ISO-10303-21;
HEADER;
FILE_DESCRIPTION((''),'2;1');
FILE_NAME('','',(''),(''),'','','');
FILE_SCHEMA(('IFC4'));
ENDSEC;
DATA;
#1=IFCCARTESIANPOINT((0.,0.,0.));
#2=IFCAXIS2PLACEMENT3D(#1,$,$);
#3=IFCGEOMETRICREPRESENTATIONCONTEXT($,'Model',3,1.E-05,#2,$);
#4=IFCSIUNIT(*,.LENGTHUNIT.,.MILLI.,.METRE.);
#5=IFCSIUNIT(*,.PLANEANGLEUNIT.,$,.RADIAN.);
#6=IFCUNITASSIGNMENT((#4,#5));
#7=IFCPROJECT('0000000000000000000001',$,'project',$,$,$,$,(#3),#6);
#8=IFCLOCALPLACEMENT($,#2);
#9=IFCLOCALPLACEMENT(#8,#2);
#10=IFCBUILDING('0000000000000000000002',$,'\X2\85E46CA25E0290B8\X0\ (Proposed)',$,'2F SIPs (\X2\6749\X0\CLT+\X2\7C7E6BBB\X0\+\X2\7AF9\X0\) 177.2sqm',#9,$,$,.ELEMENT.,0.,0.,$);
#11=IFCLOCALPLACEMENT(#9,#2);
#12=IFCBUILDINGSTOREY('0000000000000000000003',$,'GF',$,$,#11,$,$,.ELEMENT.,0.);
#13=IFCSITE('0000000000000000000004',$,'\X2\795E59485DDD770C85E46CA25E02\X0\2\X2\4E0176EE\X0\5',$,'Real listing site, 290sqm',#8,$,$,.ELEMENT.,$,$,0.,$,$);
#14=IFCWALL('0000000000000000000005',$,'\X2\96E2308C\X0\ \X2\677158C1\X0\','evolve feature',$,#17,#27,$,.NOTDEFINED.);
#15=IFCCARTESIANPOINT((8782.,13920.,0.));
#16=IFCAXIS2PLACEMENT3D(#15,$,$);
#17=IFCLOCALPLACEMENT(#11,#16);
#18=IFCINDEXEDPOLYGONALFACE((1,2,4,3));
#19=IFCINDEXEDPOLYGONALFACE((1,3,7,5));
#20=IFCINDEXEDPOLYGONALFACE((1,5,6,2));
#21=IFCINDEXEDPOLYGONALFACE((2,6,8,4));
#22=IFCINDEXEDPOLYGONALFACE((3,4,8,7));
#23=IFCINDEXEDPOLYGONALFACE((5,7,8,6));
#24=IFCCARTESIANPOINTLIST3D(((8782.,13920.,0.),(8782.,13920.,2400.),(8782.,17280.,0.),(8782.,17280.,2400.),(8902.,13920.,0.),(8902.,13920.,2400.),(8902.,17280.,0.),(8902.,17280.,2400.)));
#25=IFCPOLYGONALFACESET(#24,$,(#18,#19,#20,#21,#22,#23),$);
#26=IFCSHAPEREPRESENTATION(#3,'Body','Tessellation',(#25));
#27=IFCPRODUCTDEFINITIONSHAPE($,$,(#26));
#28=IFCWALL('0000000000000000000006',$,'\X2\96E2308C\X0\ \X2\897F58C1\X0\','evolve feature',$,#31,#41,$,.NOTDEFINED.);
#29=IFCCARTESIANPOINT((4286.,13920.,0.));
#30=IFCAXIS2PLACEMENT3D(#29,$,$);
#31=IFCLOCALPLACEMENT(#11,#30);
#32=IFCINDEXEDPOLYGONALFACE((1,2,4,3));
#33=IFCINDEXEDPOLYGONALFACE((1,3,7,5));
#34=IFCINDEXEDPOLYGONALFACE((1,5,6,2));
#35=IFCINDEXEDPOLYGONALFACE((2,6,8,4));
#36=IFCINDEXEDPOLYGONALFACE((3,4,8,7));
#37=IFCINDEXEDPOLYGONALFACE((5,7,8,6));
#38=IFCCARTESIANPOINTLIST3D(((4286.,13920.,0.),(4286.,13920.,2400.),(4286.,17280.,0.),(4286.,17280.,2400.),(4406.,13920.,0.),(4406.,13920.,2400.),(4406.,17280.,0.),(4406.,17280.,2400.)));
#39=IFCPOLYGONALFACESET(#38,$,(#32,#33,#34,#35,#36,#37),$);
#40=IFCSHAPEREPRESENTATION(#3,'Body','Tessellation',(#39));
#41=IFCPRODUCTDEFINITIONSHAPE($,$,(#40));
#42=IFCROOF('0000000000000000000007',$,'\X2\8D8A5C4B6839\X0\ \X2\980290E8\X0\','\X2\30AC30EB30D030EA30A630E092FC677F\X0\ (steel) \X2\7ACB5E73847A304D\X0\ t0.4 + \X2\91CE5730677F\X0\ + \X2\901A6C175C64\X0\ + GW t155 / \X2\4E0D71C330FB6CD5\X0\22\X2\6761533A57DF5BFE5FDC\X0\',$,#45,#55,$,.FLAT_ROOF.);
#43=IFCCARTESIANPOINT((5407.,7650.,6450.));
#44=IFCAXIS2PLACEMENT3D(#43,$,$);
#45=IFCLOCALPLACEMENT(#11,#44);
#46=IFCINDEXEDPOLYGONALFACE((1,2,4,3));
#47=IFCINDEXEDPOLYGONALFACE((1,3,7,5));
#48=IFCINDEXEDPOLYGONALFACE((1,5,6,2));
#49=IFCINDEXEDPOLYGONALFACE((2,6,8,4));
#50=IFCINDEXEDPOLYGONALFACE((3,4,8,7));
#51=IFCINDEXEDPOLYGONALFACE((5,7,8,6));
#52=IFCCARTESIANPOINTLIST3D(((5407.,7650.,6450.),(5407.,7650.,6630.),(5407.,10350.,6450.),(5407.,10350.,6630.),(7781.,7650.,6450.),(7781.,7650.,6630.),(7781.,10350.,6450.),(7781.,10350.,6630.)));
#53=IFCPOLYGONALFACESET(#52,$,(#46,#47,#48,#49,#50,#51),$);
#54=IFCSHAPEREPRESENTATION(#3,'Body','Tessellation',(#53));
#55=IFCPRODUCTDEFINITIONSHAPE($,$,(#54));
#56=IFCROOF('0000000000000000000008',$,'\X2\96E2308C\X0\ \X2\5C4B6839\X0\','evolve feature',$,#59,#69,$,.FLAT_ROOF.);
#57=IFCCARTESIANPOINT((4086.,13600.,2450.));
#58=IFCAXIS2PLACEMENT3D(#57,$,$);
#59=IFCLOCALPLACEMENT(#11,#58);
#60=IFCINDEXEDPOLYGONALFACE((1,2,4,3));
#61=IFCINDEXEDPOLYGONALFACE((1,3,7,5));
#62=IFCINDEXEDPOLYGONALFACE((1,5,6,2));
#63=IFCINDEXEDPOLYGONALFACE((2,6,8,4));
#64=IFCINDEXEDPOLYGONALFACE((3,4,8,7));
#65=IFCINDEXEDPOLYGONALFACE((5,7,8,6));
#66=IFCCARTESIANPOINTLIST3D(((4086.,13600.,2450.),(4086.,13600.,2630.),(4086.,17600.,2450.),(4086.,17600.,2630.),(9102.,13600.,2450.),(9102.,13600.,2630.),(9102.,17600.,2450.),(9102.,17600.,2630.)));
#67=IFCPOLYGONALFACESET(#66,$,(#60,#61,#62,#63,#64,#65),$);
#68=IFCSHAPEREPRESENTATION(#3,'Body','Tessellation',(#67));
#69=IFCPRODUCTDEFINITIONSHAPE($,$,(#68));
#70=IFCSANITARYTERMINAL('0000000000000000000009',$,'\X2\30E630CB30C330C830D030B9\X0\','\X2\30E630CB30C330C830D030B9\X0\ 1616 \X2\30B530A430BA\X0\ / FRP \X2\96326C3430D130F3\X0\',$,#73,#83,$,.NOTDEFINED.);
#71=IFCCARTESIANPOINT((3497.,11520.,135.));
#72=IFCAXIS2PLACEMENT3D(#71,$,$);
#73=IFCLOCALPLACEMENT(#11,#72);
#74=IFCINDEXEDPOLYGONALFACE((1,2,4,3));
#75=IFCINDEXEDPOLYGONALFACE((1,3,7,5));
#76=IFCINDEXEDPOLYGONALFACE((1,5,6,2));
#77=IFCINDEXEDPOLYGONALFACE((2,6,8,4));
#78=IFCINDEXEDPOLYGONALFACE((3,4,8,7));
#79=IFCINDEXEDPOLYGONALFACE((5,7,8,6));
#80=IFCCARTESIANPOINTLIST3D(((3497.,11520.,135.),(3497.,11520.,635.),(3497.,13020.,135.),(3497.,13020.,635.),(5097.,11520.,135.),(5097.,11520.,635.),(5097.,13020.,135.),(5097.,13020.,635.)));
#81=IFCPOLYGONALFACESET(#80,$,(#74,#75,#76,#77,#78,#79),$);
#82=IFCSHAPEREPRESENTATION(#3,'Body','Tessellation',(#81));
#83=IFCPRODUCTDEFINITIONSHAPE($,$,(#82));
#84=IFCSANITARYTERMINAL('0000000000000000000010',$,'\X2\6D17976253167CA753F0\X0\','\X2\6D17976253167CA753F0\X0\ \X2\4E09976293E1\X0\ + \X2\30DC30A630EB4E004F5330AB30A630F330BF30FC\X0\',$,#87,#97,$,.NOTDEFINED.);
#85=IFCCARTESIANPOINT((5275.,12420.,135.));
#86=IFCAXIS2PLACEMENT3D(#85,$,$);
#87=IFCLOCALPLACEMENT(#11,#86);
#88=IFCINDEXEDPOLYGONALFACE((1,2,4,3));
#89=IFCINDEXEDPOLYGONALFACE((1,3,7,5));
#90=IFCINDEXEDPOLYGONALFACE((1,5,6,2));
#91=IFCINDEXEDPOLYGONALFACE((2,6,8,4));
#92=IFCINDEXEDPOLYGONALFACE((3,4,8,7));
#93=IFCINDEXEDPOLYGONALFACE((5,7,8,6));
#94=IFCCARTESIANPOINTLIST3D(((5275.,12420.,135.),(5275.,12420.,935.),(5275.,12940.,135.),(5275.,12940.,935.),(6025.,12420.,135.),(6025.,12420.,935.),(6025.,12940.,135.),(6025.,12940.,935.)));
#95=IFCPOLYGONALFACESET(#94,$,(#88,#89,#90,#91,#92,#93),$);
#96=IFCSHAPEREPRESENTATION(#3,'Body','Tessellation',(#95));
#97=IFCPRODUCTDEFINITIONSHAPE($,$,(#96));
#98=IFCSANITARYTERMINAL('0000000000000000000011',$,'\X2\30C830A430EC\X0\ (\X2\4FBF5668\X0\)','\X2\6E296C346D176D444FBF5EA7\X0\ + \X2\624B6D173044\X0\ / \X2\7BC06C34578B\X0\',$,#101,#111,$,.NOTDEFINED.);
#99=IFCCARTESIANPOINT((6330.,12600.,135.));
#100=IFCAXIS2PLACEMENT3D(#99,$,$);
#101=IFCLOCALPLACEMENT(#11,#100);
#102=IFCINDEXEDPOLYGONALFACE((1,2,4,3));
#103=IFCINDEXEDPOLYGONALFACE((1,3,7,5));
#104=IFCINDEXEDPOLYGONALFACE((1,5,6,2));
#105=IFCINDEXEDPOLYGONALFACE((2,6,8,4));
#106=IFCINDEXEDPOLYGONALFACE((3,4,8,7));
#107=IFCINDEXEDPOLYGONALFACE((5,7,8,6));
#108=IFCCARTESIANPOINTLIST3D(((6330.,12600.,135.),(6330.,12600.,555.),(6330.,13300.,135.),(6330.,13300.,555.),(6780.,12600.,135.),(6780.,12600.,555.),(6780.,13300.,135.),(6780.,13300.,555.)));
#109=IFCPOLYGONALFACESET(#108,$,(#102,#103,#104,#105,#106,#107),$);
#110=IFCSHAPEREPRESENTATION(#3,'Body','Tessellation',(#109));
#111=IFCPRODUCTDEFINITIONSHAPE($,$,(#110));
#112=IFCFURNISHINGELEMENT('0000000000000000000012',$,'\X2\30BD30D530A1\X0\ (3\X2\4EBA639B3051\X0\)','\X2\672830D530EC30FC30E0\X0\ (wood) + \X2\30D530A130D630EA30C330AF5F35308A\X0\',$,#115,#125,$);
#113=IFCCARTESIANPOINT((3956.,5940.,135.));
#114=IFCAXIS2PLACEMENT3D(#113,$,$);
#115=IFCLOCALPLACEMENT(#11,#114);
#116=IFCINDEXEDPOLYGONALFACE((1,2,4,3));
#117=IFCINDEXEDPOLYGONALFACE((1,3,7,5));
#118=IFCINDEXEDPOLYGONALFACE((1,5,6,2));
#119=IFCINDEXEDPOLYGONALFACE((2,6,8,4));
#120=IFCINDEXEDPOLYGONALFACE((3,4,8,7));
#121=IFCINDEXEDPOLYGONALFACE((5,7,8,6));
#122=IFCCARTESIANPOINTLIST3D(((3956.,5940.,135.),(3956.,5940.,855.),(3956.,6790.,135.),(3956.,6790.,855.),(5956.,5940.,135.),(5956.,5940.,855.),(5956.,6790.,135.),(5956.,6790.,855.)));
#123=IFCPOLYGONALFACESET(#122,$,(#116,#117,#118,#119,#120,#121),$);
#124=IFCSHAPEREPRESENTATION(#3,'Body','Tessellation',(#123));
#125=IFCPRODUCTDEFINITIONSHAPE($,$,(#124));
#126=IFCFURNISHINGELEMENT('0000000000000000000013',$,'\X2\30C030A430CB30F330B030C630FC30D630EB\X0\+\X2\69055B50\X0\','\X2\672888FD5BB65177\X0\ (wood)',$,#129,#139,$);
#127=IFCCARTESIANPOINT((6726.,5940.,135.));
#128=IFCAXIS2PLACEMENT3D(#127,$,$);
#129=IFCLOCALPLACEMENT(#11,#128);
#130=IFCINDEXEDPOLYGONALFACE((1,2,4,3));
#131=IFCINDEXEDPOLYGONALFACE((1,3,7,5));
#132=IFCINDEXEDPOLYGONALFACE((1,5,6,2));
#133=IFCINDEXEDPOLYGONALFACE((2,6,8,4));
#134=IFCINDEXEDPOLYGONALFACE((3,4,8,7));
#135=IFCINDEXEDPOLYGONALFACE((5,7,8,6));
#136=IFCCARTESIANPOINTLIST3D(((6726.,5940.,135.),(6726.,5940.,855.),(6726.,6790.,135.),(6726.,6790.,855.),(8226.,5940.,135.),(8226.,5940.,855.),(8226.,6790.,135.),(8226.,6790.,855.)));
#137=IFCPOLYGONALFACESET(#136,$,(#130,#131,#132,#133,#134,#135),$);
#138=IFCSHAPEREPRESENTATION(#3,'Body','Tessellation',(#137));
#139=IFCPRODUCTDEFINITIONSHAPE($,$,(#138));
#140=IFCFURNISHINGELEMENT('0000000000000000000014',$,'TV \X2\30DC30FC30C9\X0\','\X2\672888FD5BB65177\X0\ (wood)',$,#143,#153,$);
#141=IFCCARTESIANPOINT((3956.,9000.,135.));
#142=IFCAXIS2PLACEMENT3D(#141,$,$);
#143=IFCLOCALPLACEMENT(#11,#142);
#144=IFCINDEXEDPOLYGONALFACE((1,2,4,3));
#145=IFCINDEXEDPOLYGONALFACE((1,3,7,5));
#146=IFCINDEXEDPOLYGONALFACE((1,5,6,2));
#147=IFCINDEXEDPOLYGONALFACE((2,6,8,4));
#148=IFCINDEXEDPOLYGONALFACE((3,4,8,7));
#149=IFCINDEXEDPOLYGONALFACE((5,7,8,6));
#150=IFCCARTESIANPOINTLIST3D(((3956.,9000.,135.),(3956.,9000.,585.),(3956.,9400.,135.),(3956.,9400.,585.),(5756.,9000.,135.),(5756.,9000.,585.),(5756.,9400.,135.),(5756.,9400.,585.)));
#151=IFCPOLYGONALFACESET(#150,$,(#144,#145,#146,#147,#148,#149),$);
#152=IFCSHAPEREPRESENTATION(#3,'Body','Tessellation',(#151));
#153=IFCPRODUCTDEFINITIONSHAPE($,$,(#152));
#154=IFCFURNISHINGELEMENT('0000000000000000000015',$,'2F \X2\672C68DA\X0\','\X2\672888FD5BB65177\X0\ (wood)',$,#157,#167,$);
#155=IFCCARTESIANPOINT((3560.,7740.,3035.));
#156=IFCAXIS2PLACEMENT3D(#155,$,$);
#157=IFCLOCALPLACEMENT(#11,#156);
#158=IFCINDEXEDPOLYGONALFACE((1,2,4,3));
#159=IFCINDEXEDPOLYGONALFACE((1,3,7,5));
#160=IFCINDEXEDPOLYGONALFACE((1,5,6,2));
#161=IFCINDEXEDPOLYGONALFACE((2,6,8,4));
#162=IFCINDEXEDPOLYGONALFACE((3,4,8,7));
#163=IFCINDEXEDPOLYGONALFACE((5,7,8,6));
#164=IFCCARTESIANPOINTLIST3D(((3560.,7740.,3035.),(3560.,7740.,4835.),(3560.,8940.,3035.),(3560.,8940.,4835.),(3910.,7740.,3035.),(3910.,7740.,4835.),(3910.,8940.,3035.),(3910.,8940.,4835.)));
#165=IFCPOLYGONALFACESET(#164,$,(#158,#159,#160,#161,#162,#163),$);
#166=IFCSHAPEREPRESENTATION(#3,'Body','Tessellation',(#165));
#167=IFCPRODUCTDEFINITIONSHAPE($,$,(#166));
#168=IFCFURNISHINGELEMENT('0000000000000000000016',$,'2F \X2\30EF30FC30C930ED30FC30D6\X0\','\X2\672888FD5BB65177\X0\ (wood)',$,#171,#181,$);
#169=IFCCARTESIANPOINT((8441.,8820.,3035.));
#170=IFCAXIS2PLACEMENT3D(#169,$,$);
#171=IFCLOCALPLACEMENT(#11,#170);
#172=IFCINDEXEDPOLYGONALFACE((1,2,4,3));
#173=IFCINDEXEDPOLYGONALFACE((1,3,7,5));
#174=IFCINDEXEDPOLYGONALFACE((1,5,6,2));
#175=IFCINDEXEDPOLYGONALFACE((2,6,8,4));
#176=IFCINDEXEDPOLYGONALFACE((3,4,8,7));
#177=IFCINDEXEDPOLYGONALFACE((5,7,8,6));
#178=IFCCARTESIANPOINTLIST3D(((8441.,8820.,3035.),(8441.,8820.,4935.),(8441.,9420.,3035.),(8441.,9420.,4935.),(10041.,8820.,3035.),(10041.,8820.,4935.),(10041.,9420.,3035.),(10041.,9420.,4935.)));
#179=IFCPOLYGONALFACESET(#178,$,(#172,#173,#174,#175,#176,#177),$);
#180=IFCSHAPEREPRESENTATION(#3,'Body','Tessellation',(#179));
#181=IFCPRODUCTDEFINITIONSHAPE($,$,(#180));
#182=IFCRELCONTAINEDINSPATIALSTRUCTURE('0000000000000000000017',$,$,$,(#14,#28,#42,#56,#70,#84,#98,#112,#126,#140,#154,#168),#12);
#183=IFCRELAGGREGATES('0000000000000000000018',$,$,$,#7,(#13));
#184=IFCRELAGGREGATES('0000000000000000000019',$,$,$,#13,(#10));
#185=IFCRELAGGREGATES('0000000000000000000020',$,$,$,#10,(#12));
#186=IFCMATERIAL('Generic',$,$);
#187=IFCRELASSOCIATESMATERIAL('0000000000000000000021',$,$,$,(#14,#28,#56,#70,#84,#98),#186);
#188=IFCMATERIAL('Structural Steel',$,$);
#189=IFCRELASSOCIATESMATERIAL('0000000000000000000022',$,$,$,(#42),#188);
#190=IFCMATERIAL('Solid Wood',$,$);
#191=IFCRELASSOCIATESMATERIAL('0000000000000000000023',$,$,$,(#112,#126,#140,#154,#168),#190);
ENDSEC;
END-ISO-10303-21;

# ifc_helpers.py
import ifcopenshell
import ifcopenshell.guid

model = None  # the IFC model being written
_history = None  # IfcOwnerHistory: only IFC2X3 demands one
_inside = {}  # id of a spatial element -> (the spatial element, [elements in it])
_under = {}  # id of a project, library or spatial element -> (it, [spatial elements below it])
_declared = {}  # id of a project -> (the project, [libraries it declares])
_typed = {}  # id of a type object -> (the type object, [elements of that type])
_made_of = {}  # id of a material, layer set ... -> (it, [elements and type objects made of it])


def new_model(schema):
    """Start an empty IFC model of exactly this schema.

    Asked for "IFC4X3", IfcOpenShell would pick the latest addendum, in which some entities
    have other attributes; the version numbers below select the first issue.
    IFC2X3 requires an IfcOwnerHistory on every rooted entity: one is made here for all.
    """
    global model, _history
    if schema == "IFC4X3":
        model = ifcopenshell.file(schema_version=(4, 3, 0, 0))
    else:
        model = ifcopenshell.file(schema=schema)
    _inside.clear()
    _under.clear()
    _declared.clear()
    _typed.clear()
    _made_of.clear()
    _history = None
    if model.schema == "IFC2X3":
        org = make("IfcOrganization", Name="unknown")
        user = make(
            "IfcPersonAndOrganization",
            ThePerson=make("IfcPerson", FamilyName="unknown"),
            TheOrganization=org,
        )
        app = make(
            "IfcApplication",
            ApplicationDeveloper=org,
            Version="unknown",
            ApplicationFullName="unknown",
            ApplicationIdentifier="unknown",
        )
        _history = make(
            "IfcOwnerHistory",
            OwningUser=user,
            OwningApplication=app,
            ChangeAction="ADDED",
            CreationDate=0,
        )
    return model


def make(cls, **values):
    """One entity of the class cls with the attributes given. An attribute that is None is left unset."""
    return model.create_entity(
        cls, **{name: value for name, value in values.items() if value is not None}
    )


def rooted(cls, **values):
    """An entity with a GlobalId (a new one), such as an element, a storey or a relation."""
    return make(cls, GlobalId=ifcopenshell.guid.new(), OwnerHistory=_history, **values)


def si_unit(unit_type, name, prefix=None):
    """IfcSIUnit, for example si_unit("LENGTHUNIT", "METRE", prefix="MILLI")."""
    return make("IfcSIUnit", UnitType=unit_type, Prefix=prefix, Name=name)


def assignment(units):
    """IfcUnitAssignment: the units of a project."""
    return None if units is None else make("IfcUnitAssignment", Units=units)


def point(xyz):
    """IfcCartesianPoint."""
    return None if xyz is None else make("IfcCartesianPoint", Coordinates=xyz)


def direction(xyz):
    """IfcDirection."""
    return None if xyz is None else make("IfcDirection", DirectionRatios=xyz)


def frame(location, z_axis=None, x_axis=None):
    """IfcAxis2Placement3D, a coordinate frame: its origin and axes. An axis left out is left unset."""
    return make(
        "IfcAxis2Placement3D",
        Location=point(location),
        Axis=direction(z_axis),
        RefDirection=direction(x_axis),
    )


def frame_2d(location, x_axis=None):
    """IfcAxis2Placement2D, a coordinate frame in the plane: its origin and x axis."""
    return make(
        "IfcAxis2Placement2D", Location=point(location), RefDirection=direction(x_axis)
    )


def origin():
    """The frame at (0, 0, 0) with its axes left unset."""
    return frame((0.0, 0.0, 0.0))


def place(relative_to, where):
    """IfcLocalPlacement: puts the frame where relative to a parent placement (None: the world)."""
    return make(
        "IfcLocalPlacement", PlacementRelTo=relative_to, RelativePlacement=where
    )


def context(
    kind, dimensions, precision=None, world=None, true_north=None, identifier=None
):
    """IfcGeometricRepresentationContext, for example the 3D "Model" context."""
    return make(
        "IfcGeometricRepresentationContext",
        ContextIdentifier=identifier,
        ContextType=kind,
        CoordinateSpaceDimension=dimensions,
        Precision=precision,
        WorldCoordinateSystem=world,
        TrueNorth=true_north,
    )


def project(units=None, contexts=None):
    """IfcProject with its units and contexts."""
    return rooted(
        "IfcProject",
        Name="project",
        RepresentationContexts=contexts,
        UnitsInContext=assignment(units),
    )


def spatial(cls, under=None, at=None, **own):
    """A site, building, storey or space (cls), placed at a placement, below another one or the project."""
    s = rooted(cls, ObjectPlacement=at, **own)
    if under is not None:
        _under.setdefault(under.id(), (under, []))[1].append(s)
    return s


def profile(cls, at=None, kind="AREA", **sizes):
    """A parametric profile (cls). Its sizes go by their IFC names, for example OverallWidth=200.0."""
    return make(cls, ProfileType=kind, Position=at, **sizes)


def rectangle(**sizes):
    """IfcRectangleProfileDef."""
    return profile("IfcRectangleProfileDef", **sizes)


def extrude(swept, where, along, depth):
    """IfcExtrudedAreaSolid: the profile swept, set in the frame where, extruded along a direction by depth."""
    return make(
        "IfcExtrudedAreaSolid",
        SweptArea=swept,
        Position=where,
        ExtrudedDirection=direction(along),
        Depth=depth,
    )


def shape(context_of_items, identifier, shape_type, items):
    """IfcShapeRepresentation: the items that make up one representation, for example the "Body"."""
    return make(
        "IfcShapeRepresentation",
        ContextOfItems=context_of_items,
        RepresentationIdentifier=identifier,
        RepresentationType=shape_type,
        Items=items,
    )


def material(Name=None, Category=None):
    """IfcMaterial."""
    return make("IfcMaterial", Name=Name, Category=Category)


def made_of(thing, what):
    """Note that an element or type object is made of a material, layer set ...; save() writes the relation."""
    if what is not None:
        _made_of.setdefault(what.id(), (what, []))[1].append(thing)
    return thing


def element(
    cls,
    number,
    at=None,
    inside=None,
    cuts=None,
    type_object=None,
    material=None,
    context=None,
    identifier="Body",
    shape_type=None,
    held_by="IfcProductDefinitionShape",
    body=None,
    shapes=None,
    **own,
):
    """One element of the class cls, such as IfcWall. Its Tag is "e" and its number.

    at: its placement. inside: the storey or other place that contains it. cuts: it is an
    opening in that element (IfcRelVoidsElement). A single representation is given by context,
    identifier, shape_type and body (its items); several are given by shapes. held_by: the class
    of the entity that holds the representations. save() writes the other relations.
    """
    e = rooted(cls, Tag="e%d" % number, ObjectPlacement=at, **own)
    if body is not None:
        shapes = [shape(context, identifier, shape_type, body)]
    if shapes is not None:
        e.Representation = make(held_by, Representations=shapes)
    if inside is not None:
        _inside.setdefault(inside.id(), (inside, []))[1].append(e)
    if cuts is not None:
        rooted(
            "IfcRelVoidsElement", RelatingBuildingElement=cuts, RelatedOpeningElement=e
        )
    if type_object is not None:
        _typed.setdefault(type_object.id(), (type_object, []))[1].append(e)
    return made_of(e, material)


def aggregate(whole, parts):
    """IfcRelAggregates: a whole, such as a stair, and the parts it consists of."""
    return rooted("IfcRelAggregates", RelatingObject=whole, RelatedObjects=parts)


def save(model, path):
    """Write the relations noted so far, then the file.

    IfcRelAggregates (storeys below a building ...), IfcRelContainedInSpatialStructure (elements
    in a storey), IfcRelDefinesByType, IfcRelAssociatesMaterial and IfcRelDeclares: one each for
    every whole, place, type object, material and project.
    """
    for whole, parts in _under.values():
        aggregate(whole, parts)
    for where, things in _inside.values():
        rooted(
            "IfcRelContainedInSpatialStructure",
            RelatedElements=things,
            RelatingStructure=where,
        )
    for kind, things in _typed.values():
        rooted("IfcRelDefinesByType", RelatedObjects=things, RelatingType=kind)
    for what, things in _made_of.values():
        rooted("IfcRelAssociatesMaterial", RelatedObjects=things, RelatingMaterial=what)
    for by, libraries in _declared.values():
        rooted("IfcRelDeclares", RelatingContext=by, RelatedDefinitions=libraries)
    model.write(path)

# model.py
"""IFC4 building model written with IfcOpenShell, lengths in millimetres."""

from ifc_helpers import new_model, si_unit, frame, frame_2d, origin, place, context, project, spatial, rectangle, extrude, material, element, save


model = new_model("IFC4")

# Units and contexts
model_context = context("Model", 3, precision=1e-05, world=origin())
ifc_project = project(units=[si_unit("LENGTHUNIT", "METRE", prefix="MILLI"), si_unit("PLANEANGLEUNIT", "RADIAN")], contexts=[model_context])

# Site, building, storey
site_placement = place(None, origin())
site = spatial("IfcSite", under=ifc_project, at=site_placement, Name="神奈川県藤沢市2丁目5", ObjectType="Real listing site, 290sqm", CompositionType="ELEMENT", RefElevation=0.0)
building_placement = place(site_placement, origin())
building = spatial("IfcBuilding", under=site, at=building_placement, Name="藤沢市邸 (Proposed)", ObjectType="2F SIPs (杉CLT+籾殻+竹) 177.2sqm", CompositionType="ELEMENT", ElevationOfRefHeight=0.0, ElevationOfTerrain=0.0)
storey_placement = place(building_placement, origin())
storey = spatial("IfcBuildingStorey", under=building, at=storey_placement, Name="GF", CompositionType="ELEMENT", Elevation=0.0)

# Shared definitions
ifc_material_1 = material(Name="Generic")

# Shared definitions
ifc_material_2 = material(Name="Solid Wood")

# Walls
wall_1_placement = place(storey_placement, frame((8782.0, 13920.0, 0.0)))
element("IfcWall", 1, at=wall_1_placement, inside=storey, material=ifc_material_1, Name="離れ 東壁", Description="evolve feature", PredefinedType="NOTDEFINED", context=model_context, shape_type="SweptSolid", body=[
    extrude(rectangle(XDim=120.0, YDim=3360.0, at=frame_2d((60.0, 1680.0))), frame((8782.0, 13920.0, 0.0)), (0.0, 0.0, 1.0), 2400.0),
])
wall_2_placement = place(storey_placement, frame((4286.0, 13920.0, 0.0)))
element("IfcWall", 2, at=wall_2_placement, inside=storey, material=ifc_material_1, Name="離れ 西壁", Description="evolve feature", PredefinedType="NOTDEFINED", context=model_context, shape_type="SweptSolid", body=[
    extrude(rectangle(XDim=120.0, YDim=3360.0, at=frame_2d((60.0, 1680.0))), frame((4286.0, 13920.0, 0.0)), (0.0, 0.0, 1.0), 2400.0),
])

# Roofs
ifc_material_3 = material(Name="Structural Steel")
roof_1_placement = place(storey_placement, frame((5407.0, 7650.0, 6450.0)))
element("IfcRoof", 3, at=roof_1_placement, inside=storey, material=ifc_material_3, Name="越屋根 頂部", Description="ガルバリウム鋼板 (steel) 立平葺き t0.4 + 野地板 + 通気層 + GW t155 / 不燃・法22条区域対応", PredefinedType="FLAT_ROOF", context=model_context, shape_type="SweptSolid", body=[
    extrude(rectangle(XDim=2374.0, YDim=2700.0, at=frame_2d((1187.0, 1350.0))), frame((5407.0, 7650.0, 6450.0)), (0.0, 0.0, 1.0), 180.0),
])
roof_2_placement = place(storey_placement, frame((4086.0, 13600.0, 2450.0)))
element("IfcRoof", 4, at=roof_2_placement, inside=storey, material=ifc_material_1, Name="離れ 屋根", Description="evolve feature", PredefinedType="FLAT_ROOF", context=model_context, shape_type="SweptSolid", body=[
    extrude(rectangle(XDim=5016.0, YDim=4000.0, at=frame_2d((2508.0, 2000.0))), frame((4086.0, 13600.0, 2450.0)), (0.0, 0.0, 1.0), 180.0),
])

# Sanitary terminals
sanitary_terminal_1_placement = place(storey_placement, frame((3497.0, 11520.0, 135.0)))
element("IfcSanitaryTerminal", 5, at=sanitary_terminal_1_placement, inside=storey, material=ifc_material_1, Name="ユニットバス", Description="ユニットバス 1616 サイズ / FRP 防水パン", PredefinedType="NOTDEFINED", context=model_context, shape_type="SweptSolid", body=[
    extrude(rectangle(XDim=1600.0, YDim=1500.0, at=frame_2d((800.0, 750.0))), frame((3497.0, 11520.0, 135.0)), (0.0, 0.0, 1.0), 500.0),
])
sanitary_terminal_2_placement = place(storey_placement, frame((5275.0, 12420.0, 135.0)))
element("IfcSanitaryTerminal", 6, at=sanitary_terminal_2_placement, inside=storey, material=ifc_material_1, Name="洗面化粧台", Description="洗面化粧台 三面鏡 + ボウル一体カウンター", PredefinedType="NOTDEFINED", context=model_context, shape_type="SweptSolid", body=[
    extrude(rectangle(XDim=750.0, YDim=520.0, at=frame_2d((375.0, 260.0))), frame((5275.0, 12420.0, 135.0)), (0.0, 0.0, 1.0), 800.0),
])
sanitary_terminal_3_placement = place(storey_placement, frame((6330.0, 12600.0, 135.0)))
element("IfcSanitaryTerminal", 7, at=sanitary_terminal_3_placement, inside=storey, material=ifc_material_1, Name="トイレ (便器)", Description="温水洗浄便座 + 手洗い / 節水型", PredefinedType="NOTDEFINED", context=model_context, shape_type="SweptSolid", body=[
    extrude(rectangle(XDim=450.0, YDim=700.0, at=frame_2d((225.0, 350.0))), frame((6330.0, 12600.0, 135.0)), (0.0, 0.0, 1.0), 420.0),
])

# Furnishing elements
furnishing_1_placement = place(storey_placement, frame((3956.0, 5940.0, 135.0)))
element("IfcFurnishingElement", 8, at=furnishing_1_placement, inside=storey, material=ifc_material_2, Name="ソファ (3人掛け)", Description="木フレーム (wood) + ファブリック張り", context=model_context, shape_type="SweptSolid", body=[
    extrude(rectangle(XDim=2000.0, YDim=850.0, at=frame_2d((1000.0, 425.0))), frame((3956.0, 5940.0, 135.0)), (0.0, 0.0, 1.0), 720.0),
])
furnishing_2_placement = place(storey_placement, frame((6726.0, 5940.0, 135.0)))
element("IfcFurnishingElement", 9, at=furnishing_2_placement, inside=storey, material=ifc_material_2, Name="ダイニングテーブル+椅子", Description="木製家具 (wood)", context=model_context, shape_type="SweptSolid", body=[
    extrude(rectangle(XDim=1500.0, YDim=850.0, at=frame_2d((750.0, 425.0))), frame((6726.0, 5940.0, 135.0)), (0.0, 0.0, 1.0), 720.0),
])
furnishing_3_placement = place(storey_placement, frame((3956.0, 9000.0, 135.0)))
element("IfcFurnishingElement", 10, at=furnishing_3_placement, inside=storey, material=ifc_material_2, Name="TV ボード", Description="木製家具 (wood)", context=model_context, shape_type="SweptSolid", body=[
    extrude(rectangle(XDim=1800.0, YDim=400.0, at=frame_2d((900.0, 200.0))), frame((3956.0, 9000.0, 135.0)), (0.0, 0.0, 1.0), 450.0),
])
furnishing_4_placement = place(storey_placement, frame((3560.0, 7740.0, 3035.0)))
element("IfcFurnishingElement", 11, at=furnishing_4_placement, inside=storey, material=ifc_material_2, Name="2F 本棚", Description="木製家具 (wood)", context=model_context, shape_type="SweptSolid", body=[
    extrude(rectangle(XDim=350.0, YDim=1200.0, at=frame_2d((175.0, 600.0))), frame((3560.0, 7740.0, 3035.0)), (0.0, 0.0, 1.0), 1800.0),
])
furnishing_5_placement = place(storey_placement, frame((8441.0, 8820.0, 3035.0)))
element("IfcFurnishingElement", 12, at=furnishing_5_placement, inside=storey, material=ifc_material_2, Name="2F ワードローブ", Description="木製家具 (wood)", context=model_context, shape_type="SweptSolid", body=[
    extrude(rectangle(XDim=1600.0, YDim=600.0, at=frame_2d((800.0, 300.0))), frame((8441.0, 8820.0, 3035.0)), (0.0, 0.0, 1.0), 1900.0),
])

save(model, "model.ifc")
